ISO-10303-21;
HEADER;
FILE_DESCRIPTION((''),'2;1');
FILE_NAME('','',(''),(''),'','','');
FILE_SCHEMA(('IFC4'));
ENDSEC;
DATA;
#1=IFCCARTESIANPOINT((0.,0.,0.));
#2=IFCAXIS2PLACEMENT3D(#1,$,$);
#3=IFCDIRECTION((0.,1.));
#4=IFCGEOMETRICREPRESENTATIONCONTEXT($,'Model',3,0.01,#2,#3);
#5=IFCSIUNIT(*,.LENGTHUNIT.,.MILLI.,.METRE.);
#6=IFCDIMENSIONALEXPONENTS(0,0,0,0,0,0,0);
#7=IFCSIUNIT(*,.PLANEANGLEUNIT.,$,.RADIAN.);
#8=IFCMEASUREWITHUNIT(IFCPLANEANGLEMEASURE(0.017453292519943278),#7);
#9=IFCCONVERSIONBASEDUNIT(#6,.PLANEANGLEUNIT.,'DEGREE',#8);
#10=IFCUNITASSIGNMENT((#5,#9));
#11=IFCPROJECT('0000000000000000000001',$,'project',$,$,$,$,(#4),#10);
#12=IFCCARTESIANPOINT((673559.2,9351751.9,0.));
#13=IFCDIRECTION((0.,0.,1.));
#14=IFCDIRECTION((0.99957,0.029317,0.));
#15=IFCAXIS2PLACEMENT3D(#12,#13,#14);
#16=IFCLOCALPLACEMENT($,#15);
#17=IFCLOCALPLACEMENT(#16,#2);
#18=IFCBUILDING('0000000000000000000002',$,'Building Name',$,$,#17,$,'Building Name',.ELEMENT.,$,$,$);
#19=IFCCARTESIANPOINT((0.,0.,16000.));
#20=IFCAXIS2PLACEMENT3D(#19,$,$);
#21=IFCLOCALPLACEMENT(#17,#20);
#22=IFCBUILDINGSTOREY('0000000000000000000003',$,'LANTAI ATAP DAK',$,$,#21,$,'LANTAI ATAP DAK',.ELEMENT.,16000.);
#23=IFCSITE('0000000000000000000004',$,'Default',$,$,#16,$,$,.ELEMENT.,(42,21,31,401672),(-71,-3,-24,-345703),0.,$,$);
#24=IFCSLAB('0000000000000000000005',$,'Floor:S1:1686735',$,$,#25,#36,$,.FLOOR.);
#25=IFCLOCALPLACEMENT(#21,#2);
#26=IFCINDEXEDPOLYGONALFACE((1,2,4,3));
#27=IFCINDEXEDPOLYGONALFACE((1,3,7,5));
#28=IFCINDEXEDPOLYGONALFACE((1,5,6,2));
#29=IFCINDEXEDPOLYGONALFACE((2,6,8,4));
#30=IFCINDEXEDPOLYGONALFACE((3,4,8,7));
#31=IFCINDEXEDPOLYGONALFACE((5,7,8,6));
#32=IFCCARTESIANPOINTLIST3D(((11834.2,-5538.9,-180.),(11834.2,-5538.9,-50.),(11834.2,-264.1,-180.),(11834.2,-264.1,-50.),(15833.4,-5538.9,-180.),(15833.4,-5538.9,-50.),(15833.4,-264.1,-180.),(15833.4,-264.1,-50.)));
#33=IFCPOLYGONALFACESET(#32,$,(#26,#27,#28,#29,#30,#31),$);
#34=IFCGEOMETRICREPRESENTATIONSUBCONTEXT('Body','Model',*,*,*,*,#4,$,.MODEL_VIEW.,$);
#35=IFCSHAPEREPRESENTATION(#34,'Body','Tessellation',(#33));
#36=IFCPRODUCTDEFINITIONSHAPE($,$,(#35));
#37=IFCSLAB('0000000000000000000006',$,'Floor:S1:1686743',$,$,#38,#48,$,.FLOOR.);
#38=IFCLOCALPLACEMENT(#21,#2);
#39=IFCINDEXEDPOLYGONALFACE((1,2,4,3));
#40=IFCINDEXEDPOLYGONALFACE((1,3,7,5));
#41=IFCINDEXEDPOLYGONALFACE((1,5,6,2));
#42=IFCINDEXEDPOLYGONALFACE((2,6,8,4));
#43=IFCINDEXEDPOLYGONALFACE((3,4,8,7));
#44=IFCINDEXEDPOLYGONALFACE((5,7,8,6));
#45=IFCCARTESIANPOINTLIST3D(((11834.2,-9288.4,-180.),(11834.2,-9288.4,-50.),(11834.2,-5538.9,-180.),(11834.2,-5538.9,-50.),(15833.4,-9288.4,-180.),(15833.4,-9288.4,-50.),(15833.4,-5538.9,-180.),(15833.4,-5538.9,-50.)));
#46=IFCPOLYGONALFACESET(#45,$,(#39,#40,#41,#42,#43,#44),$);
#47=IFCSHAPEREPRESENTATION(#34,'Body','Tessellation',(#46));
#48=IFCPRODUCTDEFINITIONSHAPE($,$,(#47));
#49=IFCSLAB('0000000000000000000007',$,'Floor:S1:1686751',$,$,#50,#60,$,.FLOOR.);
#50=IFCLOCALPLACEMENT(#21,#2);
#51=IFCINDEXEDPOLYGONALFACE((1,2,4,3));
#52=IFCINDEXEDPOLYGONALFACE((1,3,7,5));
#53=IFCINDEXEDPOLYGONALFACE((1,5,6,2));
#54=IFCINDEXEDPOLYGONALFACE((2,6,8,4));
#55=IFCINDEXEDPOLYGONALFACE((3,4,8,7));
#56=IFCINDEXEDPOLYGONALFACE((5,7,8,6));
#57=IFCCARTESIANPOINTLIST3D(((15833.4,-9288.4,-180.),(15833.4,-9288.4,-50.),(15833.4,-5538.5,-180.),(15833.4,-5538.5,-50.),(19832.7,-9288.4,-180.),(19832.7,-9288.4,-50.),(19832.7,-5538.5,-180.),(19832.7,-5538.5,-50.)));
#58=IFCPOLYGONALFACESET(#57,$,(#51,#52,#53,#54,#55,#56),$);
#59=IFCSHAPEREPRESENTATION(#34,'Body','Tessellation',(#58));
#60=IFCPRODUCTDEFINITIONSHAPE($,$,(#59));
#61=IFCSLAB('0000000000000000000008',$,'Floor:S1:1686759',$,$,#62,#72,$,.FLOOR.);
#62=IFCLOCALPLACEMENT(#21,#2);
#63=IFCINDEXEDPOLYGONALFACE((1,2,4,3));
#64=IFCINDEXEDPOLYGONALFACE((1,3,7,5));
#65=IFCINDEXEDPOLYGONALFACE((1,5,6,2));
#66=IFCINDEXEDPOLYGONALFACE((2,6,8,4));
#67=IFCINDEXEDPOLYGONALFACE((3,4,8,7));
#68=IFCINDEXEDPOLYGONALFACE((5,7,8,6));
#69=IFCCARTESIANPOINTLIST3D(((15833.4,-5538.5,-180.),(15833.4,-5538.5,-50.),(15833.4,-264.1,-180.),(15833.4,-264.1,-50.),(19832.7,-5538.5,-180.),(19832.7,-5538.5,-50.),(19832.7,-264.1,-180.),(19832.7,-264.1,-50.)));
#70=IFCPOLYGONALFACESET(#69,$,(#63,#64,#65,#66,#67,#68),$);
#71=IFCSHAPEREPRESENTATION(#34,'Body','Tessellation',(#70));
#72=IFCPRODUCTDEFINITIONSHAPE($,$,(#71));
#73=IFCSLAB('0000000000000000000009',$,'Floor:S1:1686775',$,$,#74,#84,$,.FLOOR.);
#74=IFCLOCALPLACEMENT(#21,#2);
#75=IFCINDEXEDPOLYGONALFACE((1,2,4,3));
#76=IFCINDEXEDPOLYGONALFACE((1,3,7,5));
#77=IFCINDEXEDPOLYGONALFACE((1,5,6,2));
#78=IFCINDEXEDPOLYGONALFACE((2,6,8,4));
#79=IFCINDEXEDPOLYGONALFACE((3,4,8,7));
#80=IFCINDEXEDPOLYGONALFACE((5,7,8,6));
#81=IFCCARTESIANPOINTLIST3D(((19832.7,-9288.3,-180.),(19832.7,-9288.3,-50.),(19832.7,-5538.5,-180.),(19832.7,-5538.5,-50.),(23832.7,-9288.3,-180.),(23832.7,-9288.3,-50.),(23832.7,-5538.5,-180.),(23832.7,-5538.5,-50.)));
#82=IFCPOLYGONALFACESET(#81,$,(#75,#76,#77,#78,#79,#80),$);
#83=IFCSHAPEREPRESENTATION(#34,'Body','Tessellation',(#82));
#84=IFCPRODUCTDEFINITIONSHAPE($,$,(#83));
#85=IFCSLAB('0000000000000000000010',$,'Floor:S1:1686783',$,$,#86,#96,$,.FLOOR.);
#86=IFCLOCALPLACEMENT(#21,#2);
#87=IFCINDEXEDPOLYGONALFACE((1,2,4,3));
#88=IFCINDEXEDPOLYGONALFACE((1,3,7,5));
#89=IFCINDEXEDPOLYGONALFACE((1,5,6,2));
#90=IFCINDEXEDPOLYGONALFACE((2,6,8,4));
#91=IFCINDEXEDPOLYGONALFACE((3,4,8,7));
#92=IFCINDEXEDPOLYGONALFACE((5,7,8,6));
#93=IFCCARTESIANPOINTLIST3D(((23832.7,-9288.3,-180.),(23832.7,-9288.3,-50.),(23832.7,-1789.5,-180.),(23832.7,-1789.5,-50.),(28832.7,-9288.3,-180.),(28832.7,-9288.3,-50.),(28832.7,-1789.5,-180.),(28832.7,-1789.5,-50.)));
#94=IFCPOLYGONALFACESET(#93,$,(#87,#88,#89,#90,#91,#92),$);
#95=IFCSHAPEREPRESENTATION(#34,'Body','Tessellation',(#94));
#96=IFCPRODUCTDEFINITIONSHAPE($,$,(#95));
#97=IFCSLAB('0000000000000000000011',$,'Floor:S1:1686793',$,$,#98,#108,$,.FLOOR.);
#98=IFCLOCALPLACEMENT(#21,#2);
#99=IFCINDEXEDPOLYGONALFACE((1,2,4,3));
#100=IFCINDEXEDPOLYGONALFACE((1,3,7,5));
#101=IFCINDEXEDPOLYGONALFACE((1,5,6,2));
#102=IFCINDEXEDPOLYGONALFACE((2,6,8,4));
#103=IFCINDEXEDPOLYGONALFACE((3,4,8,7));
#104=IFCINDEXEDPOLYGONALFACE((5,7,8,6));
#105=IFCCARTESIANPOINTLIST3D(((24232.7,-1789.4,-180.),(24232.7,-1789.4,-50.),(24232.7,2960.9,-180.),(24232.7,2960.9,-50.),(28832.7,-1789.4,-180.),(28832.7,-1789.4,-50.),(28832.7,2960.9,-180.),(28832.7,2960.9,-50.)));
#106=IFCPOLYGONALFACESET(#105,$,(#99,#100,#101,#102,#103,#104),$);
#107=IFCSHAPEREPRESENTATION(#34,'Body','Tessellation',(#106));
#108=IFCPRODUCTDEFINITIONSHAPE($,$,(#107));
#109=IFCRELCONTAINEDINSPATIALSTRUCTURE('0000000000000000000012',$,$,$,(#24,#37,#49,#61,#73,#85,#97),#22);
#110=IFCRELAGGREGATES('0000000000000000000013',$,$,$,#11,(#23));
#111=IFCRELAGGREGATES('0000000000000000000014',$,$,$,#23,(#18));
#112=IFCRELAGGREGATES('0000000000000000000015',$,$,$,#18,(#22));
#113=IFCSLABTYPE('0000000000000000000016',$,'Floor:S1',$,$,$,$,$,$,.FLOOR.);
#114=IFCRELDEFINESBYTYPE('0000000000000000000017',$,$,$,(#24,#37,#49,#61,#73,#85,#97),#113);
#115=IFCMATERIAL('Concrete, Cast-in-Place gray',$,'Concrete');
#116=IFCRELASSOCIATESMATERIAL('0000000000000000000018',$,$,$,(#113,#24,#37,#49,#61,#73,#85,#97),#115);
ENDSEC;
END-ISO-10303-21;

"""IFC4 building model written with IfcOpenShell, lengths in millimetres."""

from ifc_helpers import new_model, entity, si_unit, converted_unit, direction, frame, origin, place, context, subcontext, project, spatial, indexed_curve, outline, extrude, material, type_object, element, save


model = new_model("IFC4")

# Units and contexts
model_context = context("Model", 3, precision=0.01, world=origin(), true_north=direction((0.0, 1.0)))
body_context = subcontext(model_context, "Body", "Model", "MODEL_VIEW")
ifc_project = project(units=[si_unit("LENGTHUNIT", "METRE", prefix="MILLI"), converted_unit("PLANEANGLEUNIT", "DEGREE", entity("IfcPlaneAngleMeasure", 0.017453292519943278), si_unit("PLANEANGLEUNIT", "RADIAN"), dimensions=[0, 0, 0, 0, 0, 0, 0])], contexts=[model_context])

# Site, building, storey
site_placement = place(None, frame((673559.2, 9351751.9, 0.0), z_axis=(0.0, 0.0, 1.0), x_axis=(0.99957, 0.029317, 0.0)))
site = spatial("IfcSite", under=ifc_project, at=site_placement, Name="Default", CompositionType="ELEMENT", RefLatitude=(42, 21, 31, 401672), RefLongitude=(-71, -3, -24, -345703), RefElevation=0.0)
building_placement = place(site_placement, origin())
building = spatial("IfcBuilding", under=site, at=building_placement, Name="Building Name", LongName="Building Name", CompositionType="ELEMENT")
storey_placement = place(building_placement, frame((0.0, 0.0, 16000.0)))
storey = spatial("IfcBuildingStorey", under=building, at=storey_placement, Name="LANTAI ATAP DAK", LongName="LANTAI ATAP DAK", CompositionType="ELEMENT", Elevation=16000.0)

# Slabs
ifc_material = material(Name="Concrete, Cast-in-Place gray", Category="Concrete")
slab_type_1 = type_object("IfcSlabType", Name="Floor:S1", PredefinedType="FLOOR", material=ifc_material)
slab_1_placement = place(storey_placement, origin())
element("IfcSlab", 1, at=slab_1_placement, inside=storey, type_object=slab_type_1, material=ifc_material, Name="Floor:S1:1686735", PredefinedType="FLOOR", context=body_context, shape_type="SweptSolid", body=[
    extrude(outline(indexed_curve([(-2637.4, -1999.6), (2637.4, -1999.6), (2637.4, 1999.6), (-2637.4, 1999.6), (-2637.4, -1999.6)], self_intersect=False)), frame((13833.8, -2901.5, -50.0), z_axis=(0.0, 0.0, -1.0), x_axis=(0.0, 1.0, 0.0)), (0.0, 0.0, 1.0), 130.0),
])
slab_2_placement = place(storey_placement, origin())
element("IfcSlab", 2, at=slab_2_placement, inside=storey, type_object=slab_type_1, material=ifc_material, Name="Floor:S1:1686743", PredefinedType="FLOOR", context=body_context, shape_type="SweptSolid", body=[
    extrude(outline(indexed_curve([(-1874.7, -1999.6), (1874.7, -1999.6), (1874.7, 1999.6), (-1874.7, 1999.6), (-1874.7, -1999.6)], self_intersect=False)), frame((13833.8, -7413.6, -50.0), z_axis=(0.0, 0.0, -1.0), x_axis=(0.0, 1.0, 0.0)), (0.0, 0.0, 1.0), 130.0),
])
slab_3_placement = place(storey_placement, origin())
element("IfcSlab", 3, at=slab_3_placement, inside=storey, type_object=slab_type_1, material=ifc_material, Name="Floor:S1:1686751", PredefinedType="FLOOR", context=body_context, shape_type="SweptSolid", body=[
    extrude(outline(indexed_curve([(-1874.9, -1999.6), (1874.9, -1999.6), (1874.9, 1999.6), (-1874.9, 1999.6), (-1874.9, -1999.6)], self_intersect=False)), frame((17833.0, -7413.5, -50.0), z_axis=(0.0, 0.0, -1.0), x_axis=(0.0, 1.0, 0.0)), (0.0, 0.0, 1.0), 130.0),
])
slab_4_placement = place(storey_placement, origin())
element("IfcSlab", 4, at=slab_4_placement, inside=storey, type_object=slab_type_1, material=ifc_material, Name="Floor:S1:1686759", PredefinedType="FLOOR", context=body_context, shape_type="SweptSolid", body=[
    extrude(outline(indexed_curve([(-2637.2, -1999.6), (2637.2, -1999.6), (2637.2, 1999.6), (-2637.2, 1999.6), (-2637.2, -1999.6)], self_intersect=False)), frame((17833.0, -2901.3, -50.0), z_axis=(0.0, 0.0, -1.0), x_axis=(0.0, 1.0, 0.0)), (0.0, 0.0, 1.0), 130.0),
])
slab_5_placement = place(storey_placement, origin())
element("IfcSlab", 5, at=slab_5_placement, inside=storey, type_object=slab_type_1, material=ifc_material, Name="Floor:S1:1686775", PredefinedType="FLOOR", context=body_context, shape_type="SweptSolid", body=[
    extrude(outline(indexed_curve([(-1874.9, -2000.0), (1874.9, -2000.0), (1874.9, 2000.0), (-1874.9, 2000.0), (-1874.9, -2000.0)], self_intersect=False)), frame((21832.7, -7413.4, -50.0), z_axis=(0.0, 0.0, -1.0), x_axis=(0.0, 1.0, 0.0)), (0.0, 0.0, 1.0), 130.0),
])
slab_6_placement = place(storey_placement, origin())
element("IfcSlab", 6, at=slab_6_placement, inside=storey, type_object=slab_type_1, material=ifc_material, Name="Floor:S1:1686783", PredefinedType="FLOOR", context=body_context, shape_type="SweptSolid", body=[
    extrude(outline(indexed_curve([(-3749.4, -2500.0), (3749.4, -2500.0), (3749.4, 2500.0), (-3749.4, 2500.0), (-3749.4, -2500.0)], self_intersect=False)), frame((26332.7, -5538.9, -50.0), z_axis=(0.0, 0.0, -1.0), x_axis=(0.0, 1.0, 0.0)), (0.0, 0.0, 1.0), 130.0),
])
slab_7_placement = place(storey_placement, origin())
element("IfcSlab", 7, at=slab_7_placement, inside=storey, type_object=slab_type_1, material=ifc_material, Name="Floor:S1:1686793", PredefinedType="FLOOR", context=body_context, shape_type="SweptSolid", body=[
    extrude(outline(indexed_curve([(-2375.2, -2300.0), (2375.2, -2300.0), (2375.2, 2300.0), (-2375.2, 2300.0), (-2375.2, -2300.0)], self_intersect=False)), frame((26532.7, 585.8, -50.0), z_axis=(0.0, 0.0, -1.0), x_axis=(0.0, 1.0, 0.0)), (0.0, 0.0, 1.0), 130.0),
])

save(model, "model.ifc")
